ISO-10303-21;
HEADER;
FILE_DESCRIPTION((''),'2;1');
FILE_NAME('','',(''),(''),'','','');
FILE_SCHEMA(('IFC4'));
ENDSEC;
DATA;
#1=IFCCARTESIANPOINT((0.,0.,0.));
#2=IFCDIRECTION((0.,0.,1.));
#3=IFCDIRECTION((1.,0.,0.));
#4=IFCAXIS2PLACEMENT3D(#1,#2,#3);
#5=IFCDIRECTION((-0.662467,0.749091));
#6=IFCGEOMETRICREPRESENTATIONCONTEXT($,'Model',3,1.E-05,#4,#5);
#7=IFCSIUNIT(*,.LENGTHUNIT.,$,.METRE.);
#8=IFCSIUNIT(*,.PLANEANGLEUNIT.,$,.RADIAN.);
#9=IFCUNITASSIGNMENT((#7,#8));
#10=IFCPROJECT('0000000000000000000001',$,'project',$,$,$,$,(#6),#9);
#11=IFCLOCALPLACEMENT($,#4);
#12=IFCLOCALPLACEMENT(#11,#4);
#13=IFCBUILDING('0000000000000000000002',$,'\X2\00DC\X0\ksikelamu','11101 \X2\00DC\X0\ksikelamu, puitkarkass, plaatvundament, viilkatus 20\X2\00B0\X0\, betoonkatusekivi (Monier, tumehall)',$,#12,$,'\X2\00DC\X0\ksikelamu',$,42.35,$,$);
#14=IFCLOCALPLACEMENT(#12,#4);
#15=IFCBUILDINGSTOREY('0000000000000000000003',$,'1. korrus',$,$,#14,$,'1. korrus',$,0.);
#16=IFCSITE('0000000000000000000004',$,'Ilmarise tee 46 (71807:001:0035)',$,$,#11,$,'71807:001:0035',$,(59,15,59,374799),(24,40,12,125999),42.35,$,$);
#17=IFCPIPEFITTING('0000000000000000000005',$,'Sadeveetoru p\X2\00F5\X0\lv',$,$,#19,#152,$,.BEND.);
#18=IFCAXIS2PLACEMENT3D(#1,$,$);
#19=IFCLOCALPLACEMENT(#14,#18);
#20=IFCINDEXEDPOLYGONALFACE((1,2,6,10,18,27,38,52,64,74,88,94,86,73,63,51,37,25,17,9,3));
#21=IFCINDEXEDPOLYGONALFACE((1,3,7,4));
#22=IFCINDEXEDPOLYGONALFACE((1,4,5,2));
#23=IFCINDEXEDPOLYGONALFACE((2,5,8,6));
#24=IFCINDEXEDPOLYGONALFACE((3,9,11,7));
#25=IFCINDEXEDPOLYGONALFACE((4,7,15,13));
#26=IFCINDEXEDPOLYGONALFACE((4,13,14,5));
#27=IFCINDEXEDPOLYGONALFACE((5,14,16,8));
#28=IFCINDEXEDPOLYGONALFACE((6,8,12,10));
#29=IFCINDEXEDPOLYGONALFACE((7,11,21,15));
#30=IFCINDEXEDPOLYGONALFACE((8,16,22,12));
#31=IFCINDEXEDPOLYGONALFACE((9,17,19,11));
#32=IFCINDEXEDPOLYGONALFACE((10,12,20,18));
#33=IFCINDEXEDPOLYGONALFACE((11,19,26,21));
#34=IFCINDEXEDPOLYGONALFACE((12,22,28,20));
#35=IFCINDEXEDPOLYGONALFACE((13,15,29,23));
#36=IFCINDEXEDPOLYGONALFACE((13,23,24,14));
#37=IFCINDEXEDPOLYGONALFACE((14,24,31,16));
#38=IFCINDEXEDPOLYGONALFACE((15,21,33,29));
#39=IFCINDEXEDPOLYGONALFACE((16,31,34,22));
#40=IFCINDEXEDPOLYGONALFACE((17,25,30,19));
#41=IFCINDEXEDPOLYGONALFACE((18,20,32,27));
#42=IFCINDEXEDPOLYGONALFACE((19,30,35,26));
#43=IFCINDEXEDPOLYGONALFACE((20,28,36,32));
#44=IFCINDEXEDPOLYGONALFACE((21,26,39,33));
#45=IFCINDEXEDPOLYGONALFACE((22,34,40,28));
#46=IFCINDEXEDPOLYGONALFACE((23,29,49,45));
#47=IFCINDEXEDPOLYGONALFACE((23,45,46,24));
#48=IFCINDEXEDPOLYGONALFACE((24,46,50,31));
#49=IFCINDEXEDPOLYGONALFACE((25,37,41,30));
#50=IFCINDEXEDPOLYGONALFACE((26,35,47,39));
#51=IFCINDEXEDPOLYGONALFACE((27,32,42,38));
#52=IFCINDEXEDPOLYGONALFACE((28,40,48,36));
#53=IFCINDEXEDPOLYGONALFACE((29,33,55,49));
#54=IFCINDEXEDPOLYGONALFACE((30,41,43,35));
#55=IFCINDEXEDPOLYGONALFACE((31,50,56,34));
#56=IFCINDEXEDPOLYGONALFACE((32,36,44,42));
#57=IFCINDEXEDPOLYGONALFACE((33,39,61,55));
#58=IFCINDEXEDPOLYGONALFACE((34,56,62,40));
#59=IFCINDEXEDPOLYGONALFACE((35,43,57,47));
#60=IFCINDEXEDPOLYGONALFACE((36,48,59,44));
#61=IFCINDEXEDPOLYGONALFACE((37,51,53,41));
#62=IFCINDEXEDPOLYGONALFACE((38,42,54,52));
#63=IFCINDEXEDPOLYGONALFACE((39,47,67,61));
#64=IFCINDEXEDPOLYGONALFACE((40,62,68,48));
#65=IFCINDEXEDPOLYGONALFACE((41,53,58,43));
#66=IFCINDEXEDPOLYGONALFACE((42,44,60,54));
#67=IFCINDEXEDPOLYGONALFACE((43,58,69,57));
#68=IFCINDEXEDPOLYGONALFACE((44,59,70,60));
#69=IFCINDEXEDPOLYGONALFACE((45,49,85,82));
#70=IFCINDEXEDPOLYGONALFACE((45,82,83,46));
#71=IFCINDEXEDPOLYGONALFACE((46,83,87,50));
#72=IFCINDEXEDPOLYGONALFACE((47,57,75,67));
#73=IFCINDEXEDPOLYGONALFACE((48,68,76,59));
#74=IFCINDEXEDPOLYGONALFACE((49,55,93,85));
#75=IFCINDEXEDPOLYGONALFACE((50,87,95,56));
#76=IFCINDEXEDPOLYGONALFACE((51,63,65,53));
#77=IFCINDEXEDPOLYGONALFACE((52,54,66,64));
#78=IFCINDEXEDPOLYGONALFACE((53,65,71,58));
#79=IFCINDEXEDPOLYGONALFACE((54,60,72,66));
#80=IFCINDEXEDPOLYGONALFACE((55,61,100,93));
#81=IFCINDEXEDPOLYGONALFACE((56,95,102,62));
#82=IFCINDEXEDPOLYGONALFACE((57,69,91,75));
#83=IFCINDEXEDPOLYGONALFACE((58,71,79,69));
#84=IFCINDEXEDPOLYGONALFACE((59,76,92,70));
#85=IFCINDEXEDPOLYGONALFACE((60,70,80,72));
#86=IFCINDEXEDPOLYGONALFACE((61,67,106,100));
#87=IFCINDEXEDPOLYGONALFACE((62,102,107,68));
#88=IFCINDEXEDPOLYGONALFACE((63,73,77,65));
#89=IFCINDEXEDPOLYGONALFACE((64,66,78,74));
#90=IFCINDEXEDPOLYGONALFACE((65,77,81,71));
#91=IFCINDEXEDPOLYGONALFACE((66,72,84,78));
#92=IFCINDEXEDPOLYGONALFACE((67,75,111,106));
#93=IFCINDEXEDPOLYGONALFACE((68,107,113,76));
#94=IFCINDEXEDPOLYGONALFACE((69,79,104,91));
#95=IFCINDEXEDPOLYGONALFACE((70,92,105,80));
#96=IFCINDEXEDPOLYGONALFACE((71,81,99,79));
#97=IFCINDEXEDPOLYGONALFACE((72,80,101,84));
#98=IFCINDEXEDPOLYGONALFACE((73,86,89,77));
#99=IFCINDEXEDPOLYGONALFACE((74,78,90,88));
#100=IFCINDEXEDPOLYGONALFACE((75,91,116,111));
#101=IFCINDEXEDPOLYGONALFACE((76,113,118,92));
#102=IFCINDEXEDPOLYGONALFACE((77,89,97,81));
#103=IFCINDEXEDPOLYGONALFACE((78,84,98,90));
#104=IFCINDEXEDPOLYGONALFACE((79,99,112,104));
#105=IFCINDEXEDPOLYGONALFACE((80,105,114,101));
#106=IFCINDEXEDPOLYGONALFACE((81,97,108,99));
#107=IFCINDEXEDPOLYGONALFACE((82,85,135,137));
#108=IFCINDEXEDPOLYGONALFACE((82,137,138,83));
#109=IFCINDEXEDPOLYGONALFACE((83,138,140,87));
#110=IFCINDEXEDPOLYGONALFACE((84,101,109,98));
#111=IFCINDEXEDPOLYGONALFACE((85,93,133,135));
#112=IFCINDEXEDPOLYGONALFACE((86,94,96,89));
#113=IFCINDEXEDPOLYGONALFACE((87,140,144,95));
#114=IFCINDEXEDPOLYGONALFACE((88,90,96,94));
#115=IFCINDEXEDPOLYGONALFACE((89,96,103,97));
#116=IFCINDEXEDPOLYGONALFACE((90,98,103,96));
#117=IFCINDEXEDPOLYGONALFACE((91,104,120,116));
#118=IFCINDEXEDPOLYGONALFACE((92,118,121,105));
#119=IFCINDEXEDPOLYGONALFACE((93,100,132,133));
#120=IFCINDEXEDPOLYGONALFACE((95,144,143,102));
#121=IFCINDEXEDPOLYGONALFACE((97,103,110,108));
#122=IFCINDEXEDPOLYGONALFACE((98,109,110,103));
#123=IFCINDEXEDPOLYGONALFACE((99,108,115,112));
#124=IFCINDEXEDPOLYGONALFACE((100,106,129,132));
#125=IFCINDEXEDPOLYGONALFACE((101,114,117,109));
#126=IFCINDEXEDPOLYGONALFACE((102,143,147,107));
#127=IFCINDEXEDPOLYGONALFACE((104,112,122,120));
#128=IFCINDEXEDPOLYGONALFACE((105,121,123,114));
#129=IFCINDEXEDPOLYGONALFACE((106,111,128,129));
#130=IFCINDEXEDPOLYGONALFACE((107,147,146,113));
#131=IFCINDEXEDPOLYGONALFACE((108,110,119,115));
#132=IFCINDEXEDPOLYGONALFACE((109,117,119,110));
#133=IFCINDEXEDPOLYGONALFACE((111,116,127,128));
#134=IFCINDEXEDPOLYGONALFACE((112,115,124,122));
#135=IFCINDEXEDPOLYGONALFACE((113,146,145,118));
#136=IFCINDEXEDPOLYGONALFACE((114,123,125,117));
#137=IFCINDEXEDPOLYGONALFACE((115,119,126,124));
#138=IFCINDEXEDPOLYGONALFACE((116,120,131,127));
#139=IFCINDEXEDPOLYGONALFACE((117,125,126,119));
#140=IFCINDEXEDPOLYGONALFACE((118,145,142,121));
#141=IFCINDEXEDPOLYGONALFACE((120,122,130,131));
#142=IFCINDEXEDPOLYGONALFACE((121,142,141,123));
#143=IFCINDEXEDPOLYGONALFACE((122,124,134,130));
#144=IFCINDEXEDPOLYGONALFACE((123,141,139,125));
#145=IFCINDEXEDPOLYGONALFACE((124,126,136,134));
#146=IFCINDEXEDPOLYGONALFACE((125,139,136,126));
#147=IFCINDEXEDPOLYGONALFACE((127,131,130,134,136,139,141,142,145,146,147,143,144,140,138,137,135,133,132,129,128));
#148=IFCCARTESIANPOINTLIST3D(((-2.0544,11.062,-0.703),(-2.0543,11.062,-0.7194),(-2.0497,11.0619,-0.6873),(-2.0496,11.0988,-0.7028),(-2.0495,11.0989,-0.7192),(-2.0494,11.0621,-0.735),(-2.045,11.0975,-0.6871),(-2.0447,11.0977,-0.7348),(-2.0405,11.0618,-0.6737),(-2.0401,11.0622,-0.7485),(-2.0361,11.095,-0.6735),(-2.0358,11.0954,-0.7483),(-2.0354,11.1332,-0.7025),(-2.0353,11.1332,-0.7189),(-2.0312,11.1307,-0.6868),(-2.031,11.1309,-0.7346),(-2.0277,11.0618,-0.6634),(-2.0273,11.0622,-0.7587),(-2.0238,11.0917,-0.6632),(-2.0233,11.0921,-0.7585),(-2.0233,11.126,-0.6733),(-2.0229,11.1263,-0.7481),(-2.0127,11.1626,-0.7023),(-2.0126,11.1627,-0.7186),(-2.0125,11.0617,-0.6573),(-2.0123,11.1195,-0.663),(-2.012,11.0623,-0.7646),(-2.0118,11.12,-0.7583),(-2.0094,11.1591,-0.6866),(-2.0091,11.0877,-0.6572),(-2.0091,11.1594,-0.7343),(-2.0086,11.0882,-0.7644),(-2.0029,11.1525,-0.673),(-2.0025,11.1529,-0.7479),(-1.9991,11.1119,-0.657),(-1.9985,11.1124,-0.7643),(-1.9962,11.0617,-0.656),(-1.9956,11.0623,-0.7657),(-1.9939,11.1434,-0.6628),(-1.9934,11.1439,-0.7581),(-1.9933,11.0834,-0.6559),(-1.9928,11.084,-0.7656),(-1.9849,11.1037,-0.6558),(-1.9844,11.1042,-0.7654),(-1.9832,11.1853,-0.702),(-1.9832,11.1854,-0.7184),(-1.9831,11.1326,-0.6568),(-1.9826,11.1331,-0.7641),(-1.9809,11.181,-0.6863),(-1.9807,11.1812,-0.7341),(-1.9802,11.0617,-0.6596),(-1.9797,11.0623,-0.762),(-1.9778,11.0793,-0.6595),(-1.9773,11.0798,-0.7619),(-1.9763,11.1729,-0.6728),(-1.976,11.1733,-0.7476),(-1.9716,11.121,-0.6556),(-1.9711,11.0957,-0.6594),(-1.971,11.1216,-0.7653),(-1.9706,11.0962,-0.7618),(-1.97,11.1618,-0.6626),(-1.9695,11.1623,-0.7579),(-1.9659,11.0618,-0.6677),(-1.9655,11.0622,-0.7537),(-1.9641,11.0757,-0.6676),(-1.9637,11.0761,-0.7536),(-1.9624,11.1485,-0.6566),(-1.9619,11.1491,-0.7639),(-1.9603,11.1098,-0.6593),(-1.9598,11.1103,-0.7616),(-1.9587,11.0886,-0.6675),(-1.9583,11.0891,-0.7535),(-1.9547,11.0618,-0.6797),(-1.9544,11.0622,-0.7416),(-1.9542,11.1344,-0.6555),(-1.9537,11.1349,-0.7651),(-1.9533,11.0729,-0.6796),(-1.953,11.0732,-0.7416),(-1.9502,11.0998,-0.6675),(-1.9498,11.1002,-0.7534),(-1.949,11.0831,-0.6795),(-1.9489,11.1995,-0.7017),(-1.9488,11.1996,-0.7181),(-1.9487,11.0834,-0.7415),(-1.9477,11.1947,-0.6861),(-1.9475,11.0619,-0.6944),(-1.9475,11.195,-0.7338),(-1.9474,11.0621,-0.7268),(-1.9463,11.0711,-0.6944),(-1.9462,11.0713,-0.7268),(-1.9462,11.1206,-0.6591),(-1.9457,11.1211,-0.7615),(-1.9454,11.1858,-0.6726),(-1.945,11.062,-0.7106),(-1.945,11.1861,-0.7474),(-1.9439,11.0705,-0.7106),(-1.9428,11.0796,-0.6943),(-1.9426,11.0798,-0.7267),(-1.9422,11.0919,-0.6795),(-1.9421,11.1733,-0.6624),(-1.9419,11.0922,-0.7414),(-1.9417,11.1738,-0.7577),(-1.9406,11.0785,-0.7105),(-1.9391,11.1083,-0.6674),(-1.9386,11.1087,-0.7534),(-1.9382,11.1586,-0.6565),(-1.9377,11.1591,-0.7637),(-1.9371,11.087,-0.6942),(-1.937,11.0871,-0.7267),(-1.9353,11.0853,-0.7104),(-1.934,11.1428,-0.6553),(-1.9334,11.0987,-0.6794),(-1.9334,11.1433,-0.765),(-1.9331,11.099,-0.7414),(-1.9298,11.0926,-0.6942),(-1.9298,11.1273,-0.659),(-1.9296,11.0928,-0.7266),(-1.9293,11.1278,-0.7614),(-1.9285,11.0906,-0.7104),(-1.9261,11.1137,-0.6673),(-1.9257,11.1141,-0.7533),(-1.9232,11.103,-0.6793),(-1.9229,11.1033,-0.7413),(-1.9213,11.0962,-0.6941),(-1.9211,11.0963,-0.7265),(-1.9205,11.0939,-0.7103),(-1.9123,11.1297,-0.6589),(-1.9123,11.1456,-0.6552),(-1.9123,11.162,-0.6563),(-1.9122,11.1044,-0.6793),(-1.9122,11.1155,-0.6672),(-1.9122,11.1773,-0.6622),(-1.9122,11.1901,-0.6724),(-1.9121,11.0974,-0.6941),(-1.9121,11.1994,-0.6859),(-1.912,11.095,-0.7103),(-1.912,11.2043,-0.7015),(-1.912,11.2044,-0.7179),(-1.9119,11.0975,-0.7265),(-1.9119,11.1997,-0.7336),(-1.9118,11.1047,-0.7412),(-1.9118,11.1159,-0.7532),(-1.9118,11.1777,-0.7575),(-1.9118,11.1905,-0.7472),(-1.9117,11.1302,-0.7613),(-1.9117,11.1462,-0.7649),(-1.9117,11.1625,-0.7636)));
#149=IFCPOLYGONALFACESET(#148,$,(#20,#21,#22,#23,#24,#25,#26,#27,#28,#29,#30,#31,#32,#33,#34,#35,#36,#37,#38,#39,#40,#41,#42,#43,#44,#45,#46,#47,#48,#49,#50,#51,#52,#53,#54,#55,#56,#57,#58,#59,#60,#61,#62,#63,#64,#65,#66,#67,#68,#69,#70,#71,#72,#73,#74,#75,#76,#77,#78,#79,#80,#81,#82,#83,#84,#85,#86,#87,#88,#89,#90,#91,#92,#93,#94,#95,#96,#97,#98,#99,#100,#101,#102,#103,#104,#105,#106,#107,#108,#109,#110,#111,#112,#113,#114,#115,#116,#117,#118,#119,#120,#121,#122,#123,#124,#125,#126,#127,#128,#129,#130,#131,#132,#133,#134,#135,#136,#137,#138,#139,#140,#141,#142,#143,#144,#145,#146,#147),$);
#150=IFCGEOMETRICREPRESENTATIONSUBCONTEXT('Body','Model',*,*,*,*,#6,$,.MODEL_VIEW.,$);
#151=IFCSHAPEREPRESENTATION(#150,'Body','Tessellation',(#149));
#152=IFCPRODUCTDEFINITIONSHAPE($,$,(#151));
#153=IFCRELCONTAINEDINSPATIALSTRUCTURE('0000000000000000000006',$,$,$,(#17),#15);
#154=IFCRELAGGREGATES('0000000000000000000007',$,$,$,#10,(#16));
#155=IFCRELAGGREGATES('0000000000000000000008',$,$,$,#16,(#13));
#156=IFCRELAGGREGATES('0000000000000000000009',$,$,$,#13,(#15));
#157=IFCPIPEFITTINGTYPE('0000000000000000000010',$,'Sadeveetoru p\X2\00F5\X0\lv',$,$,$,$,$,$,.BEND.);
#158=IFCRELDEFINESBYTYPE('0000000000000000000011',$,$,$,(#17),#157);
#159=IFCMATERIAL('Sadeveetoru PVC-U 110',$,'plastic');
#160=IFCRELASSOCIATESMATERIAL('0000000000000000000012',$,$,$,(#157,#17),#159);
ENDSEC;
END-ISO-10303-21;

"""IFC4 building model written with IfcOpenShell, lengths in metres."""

from ifc_helpers import new_model, entity, si_unit, direction, frame, origin_with_axes, place, context, subcontext, project, spatial, material, type_object, element, save


model = new_model("IFC4")

# Units and contexts
model_context = context("Model", 3, precision=1e-05, world=origin_with_axes(), true_north=direction((-0.662467, 0.749091)))
body_context = subcontext(model_context, "Body", "Model", "MODEL_VIEW")
ifc_project = project(units=[si_unit("LENGTHUNIT", "METRE"), si_unit("PLANEANGLEUNIT", "RADIAN")], contexts=[model_context])

# Site, building, storey
site_placement = place(None, origin_with_axes())
site = spatial("IfcSite", under=ifc_project, at=site_placement, Name="Ilmarise tee 46 (71807:001:0035)", LongName="71807:001:0035", RefLatitude=(59, 15, 59, 374799), RefLongitude=(24, 40, 12, 125999), RefElevation=42.35)
building_placement = place(site_placement, origin_with_axes())
building = spatial("IfcBuilding", under=site, at=building_placement, Name="Üksikelamu", Description="11101 Üksikelamu, puitkarkass, plaatvundament, viilkatus 20°, betoonkatusekivi (Monier, tumehall)", LongName="Üksikelamu", ElevationOfRefHeight=42.35)
storey_placement = place(building_placement, origin_with_axes())
storey = spatial("IfcBuildingStorey", under=building, at=storey_placement, Name="1. korrus", LongName="1. korrus", Elevation=0.0)

# Pipe fitting
ifc_material_1 = material(Name="Sadeveetoru PVC-U 110", Category="plastic")
pipe_fitting_type_1 = type_object("IfcPipeFittingType", Name="Sadeveetoru põlv", PredefinedType="BEND", material=ifc_material_1)
pipe_fitting_1_placement = place(storey_placement, frame((-2.0, 11.15, -0.7105), z_axis=(0.0, 0.0, 1.0), x_axis=(1.0, 0.0, 0.0)))
element("IfcPipeFitting", 1, at=pipe_fitting_1_placement, inside=storey, type_object=pipe_fitting_type_1, material=ifc_material_1, Name="Sadeveetoru põlv", PredefinedType="BEND", context=body_context, shape_type="SweptSolid", body=[
    entity("IfcRevolvedAreaSolid", entity("IfcCircleProfileDef", "AREA", None, None, 0.055), entity("IfcAxis2Placement3D", entity("IfcCartesianPoint", [0.088, 0.0, 0.0004]), entity("IfcDirection", [-0.999988, 0.0, -0.005]), entity("IfcDirection", [0.000025, -0.999988, -0.005])), entity("IfcAxis1Placement", entity("IfcCartesianPoint", [0.088, 0.0, 0.0]), entity("IfcDirection", [0.0, 1.0, 0.0])), 1.570771),
])

save(model, "model.ifc")
